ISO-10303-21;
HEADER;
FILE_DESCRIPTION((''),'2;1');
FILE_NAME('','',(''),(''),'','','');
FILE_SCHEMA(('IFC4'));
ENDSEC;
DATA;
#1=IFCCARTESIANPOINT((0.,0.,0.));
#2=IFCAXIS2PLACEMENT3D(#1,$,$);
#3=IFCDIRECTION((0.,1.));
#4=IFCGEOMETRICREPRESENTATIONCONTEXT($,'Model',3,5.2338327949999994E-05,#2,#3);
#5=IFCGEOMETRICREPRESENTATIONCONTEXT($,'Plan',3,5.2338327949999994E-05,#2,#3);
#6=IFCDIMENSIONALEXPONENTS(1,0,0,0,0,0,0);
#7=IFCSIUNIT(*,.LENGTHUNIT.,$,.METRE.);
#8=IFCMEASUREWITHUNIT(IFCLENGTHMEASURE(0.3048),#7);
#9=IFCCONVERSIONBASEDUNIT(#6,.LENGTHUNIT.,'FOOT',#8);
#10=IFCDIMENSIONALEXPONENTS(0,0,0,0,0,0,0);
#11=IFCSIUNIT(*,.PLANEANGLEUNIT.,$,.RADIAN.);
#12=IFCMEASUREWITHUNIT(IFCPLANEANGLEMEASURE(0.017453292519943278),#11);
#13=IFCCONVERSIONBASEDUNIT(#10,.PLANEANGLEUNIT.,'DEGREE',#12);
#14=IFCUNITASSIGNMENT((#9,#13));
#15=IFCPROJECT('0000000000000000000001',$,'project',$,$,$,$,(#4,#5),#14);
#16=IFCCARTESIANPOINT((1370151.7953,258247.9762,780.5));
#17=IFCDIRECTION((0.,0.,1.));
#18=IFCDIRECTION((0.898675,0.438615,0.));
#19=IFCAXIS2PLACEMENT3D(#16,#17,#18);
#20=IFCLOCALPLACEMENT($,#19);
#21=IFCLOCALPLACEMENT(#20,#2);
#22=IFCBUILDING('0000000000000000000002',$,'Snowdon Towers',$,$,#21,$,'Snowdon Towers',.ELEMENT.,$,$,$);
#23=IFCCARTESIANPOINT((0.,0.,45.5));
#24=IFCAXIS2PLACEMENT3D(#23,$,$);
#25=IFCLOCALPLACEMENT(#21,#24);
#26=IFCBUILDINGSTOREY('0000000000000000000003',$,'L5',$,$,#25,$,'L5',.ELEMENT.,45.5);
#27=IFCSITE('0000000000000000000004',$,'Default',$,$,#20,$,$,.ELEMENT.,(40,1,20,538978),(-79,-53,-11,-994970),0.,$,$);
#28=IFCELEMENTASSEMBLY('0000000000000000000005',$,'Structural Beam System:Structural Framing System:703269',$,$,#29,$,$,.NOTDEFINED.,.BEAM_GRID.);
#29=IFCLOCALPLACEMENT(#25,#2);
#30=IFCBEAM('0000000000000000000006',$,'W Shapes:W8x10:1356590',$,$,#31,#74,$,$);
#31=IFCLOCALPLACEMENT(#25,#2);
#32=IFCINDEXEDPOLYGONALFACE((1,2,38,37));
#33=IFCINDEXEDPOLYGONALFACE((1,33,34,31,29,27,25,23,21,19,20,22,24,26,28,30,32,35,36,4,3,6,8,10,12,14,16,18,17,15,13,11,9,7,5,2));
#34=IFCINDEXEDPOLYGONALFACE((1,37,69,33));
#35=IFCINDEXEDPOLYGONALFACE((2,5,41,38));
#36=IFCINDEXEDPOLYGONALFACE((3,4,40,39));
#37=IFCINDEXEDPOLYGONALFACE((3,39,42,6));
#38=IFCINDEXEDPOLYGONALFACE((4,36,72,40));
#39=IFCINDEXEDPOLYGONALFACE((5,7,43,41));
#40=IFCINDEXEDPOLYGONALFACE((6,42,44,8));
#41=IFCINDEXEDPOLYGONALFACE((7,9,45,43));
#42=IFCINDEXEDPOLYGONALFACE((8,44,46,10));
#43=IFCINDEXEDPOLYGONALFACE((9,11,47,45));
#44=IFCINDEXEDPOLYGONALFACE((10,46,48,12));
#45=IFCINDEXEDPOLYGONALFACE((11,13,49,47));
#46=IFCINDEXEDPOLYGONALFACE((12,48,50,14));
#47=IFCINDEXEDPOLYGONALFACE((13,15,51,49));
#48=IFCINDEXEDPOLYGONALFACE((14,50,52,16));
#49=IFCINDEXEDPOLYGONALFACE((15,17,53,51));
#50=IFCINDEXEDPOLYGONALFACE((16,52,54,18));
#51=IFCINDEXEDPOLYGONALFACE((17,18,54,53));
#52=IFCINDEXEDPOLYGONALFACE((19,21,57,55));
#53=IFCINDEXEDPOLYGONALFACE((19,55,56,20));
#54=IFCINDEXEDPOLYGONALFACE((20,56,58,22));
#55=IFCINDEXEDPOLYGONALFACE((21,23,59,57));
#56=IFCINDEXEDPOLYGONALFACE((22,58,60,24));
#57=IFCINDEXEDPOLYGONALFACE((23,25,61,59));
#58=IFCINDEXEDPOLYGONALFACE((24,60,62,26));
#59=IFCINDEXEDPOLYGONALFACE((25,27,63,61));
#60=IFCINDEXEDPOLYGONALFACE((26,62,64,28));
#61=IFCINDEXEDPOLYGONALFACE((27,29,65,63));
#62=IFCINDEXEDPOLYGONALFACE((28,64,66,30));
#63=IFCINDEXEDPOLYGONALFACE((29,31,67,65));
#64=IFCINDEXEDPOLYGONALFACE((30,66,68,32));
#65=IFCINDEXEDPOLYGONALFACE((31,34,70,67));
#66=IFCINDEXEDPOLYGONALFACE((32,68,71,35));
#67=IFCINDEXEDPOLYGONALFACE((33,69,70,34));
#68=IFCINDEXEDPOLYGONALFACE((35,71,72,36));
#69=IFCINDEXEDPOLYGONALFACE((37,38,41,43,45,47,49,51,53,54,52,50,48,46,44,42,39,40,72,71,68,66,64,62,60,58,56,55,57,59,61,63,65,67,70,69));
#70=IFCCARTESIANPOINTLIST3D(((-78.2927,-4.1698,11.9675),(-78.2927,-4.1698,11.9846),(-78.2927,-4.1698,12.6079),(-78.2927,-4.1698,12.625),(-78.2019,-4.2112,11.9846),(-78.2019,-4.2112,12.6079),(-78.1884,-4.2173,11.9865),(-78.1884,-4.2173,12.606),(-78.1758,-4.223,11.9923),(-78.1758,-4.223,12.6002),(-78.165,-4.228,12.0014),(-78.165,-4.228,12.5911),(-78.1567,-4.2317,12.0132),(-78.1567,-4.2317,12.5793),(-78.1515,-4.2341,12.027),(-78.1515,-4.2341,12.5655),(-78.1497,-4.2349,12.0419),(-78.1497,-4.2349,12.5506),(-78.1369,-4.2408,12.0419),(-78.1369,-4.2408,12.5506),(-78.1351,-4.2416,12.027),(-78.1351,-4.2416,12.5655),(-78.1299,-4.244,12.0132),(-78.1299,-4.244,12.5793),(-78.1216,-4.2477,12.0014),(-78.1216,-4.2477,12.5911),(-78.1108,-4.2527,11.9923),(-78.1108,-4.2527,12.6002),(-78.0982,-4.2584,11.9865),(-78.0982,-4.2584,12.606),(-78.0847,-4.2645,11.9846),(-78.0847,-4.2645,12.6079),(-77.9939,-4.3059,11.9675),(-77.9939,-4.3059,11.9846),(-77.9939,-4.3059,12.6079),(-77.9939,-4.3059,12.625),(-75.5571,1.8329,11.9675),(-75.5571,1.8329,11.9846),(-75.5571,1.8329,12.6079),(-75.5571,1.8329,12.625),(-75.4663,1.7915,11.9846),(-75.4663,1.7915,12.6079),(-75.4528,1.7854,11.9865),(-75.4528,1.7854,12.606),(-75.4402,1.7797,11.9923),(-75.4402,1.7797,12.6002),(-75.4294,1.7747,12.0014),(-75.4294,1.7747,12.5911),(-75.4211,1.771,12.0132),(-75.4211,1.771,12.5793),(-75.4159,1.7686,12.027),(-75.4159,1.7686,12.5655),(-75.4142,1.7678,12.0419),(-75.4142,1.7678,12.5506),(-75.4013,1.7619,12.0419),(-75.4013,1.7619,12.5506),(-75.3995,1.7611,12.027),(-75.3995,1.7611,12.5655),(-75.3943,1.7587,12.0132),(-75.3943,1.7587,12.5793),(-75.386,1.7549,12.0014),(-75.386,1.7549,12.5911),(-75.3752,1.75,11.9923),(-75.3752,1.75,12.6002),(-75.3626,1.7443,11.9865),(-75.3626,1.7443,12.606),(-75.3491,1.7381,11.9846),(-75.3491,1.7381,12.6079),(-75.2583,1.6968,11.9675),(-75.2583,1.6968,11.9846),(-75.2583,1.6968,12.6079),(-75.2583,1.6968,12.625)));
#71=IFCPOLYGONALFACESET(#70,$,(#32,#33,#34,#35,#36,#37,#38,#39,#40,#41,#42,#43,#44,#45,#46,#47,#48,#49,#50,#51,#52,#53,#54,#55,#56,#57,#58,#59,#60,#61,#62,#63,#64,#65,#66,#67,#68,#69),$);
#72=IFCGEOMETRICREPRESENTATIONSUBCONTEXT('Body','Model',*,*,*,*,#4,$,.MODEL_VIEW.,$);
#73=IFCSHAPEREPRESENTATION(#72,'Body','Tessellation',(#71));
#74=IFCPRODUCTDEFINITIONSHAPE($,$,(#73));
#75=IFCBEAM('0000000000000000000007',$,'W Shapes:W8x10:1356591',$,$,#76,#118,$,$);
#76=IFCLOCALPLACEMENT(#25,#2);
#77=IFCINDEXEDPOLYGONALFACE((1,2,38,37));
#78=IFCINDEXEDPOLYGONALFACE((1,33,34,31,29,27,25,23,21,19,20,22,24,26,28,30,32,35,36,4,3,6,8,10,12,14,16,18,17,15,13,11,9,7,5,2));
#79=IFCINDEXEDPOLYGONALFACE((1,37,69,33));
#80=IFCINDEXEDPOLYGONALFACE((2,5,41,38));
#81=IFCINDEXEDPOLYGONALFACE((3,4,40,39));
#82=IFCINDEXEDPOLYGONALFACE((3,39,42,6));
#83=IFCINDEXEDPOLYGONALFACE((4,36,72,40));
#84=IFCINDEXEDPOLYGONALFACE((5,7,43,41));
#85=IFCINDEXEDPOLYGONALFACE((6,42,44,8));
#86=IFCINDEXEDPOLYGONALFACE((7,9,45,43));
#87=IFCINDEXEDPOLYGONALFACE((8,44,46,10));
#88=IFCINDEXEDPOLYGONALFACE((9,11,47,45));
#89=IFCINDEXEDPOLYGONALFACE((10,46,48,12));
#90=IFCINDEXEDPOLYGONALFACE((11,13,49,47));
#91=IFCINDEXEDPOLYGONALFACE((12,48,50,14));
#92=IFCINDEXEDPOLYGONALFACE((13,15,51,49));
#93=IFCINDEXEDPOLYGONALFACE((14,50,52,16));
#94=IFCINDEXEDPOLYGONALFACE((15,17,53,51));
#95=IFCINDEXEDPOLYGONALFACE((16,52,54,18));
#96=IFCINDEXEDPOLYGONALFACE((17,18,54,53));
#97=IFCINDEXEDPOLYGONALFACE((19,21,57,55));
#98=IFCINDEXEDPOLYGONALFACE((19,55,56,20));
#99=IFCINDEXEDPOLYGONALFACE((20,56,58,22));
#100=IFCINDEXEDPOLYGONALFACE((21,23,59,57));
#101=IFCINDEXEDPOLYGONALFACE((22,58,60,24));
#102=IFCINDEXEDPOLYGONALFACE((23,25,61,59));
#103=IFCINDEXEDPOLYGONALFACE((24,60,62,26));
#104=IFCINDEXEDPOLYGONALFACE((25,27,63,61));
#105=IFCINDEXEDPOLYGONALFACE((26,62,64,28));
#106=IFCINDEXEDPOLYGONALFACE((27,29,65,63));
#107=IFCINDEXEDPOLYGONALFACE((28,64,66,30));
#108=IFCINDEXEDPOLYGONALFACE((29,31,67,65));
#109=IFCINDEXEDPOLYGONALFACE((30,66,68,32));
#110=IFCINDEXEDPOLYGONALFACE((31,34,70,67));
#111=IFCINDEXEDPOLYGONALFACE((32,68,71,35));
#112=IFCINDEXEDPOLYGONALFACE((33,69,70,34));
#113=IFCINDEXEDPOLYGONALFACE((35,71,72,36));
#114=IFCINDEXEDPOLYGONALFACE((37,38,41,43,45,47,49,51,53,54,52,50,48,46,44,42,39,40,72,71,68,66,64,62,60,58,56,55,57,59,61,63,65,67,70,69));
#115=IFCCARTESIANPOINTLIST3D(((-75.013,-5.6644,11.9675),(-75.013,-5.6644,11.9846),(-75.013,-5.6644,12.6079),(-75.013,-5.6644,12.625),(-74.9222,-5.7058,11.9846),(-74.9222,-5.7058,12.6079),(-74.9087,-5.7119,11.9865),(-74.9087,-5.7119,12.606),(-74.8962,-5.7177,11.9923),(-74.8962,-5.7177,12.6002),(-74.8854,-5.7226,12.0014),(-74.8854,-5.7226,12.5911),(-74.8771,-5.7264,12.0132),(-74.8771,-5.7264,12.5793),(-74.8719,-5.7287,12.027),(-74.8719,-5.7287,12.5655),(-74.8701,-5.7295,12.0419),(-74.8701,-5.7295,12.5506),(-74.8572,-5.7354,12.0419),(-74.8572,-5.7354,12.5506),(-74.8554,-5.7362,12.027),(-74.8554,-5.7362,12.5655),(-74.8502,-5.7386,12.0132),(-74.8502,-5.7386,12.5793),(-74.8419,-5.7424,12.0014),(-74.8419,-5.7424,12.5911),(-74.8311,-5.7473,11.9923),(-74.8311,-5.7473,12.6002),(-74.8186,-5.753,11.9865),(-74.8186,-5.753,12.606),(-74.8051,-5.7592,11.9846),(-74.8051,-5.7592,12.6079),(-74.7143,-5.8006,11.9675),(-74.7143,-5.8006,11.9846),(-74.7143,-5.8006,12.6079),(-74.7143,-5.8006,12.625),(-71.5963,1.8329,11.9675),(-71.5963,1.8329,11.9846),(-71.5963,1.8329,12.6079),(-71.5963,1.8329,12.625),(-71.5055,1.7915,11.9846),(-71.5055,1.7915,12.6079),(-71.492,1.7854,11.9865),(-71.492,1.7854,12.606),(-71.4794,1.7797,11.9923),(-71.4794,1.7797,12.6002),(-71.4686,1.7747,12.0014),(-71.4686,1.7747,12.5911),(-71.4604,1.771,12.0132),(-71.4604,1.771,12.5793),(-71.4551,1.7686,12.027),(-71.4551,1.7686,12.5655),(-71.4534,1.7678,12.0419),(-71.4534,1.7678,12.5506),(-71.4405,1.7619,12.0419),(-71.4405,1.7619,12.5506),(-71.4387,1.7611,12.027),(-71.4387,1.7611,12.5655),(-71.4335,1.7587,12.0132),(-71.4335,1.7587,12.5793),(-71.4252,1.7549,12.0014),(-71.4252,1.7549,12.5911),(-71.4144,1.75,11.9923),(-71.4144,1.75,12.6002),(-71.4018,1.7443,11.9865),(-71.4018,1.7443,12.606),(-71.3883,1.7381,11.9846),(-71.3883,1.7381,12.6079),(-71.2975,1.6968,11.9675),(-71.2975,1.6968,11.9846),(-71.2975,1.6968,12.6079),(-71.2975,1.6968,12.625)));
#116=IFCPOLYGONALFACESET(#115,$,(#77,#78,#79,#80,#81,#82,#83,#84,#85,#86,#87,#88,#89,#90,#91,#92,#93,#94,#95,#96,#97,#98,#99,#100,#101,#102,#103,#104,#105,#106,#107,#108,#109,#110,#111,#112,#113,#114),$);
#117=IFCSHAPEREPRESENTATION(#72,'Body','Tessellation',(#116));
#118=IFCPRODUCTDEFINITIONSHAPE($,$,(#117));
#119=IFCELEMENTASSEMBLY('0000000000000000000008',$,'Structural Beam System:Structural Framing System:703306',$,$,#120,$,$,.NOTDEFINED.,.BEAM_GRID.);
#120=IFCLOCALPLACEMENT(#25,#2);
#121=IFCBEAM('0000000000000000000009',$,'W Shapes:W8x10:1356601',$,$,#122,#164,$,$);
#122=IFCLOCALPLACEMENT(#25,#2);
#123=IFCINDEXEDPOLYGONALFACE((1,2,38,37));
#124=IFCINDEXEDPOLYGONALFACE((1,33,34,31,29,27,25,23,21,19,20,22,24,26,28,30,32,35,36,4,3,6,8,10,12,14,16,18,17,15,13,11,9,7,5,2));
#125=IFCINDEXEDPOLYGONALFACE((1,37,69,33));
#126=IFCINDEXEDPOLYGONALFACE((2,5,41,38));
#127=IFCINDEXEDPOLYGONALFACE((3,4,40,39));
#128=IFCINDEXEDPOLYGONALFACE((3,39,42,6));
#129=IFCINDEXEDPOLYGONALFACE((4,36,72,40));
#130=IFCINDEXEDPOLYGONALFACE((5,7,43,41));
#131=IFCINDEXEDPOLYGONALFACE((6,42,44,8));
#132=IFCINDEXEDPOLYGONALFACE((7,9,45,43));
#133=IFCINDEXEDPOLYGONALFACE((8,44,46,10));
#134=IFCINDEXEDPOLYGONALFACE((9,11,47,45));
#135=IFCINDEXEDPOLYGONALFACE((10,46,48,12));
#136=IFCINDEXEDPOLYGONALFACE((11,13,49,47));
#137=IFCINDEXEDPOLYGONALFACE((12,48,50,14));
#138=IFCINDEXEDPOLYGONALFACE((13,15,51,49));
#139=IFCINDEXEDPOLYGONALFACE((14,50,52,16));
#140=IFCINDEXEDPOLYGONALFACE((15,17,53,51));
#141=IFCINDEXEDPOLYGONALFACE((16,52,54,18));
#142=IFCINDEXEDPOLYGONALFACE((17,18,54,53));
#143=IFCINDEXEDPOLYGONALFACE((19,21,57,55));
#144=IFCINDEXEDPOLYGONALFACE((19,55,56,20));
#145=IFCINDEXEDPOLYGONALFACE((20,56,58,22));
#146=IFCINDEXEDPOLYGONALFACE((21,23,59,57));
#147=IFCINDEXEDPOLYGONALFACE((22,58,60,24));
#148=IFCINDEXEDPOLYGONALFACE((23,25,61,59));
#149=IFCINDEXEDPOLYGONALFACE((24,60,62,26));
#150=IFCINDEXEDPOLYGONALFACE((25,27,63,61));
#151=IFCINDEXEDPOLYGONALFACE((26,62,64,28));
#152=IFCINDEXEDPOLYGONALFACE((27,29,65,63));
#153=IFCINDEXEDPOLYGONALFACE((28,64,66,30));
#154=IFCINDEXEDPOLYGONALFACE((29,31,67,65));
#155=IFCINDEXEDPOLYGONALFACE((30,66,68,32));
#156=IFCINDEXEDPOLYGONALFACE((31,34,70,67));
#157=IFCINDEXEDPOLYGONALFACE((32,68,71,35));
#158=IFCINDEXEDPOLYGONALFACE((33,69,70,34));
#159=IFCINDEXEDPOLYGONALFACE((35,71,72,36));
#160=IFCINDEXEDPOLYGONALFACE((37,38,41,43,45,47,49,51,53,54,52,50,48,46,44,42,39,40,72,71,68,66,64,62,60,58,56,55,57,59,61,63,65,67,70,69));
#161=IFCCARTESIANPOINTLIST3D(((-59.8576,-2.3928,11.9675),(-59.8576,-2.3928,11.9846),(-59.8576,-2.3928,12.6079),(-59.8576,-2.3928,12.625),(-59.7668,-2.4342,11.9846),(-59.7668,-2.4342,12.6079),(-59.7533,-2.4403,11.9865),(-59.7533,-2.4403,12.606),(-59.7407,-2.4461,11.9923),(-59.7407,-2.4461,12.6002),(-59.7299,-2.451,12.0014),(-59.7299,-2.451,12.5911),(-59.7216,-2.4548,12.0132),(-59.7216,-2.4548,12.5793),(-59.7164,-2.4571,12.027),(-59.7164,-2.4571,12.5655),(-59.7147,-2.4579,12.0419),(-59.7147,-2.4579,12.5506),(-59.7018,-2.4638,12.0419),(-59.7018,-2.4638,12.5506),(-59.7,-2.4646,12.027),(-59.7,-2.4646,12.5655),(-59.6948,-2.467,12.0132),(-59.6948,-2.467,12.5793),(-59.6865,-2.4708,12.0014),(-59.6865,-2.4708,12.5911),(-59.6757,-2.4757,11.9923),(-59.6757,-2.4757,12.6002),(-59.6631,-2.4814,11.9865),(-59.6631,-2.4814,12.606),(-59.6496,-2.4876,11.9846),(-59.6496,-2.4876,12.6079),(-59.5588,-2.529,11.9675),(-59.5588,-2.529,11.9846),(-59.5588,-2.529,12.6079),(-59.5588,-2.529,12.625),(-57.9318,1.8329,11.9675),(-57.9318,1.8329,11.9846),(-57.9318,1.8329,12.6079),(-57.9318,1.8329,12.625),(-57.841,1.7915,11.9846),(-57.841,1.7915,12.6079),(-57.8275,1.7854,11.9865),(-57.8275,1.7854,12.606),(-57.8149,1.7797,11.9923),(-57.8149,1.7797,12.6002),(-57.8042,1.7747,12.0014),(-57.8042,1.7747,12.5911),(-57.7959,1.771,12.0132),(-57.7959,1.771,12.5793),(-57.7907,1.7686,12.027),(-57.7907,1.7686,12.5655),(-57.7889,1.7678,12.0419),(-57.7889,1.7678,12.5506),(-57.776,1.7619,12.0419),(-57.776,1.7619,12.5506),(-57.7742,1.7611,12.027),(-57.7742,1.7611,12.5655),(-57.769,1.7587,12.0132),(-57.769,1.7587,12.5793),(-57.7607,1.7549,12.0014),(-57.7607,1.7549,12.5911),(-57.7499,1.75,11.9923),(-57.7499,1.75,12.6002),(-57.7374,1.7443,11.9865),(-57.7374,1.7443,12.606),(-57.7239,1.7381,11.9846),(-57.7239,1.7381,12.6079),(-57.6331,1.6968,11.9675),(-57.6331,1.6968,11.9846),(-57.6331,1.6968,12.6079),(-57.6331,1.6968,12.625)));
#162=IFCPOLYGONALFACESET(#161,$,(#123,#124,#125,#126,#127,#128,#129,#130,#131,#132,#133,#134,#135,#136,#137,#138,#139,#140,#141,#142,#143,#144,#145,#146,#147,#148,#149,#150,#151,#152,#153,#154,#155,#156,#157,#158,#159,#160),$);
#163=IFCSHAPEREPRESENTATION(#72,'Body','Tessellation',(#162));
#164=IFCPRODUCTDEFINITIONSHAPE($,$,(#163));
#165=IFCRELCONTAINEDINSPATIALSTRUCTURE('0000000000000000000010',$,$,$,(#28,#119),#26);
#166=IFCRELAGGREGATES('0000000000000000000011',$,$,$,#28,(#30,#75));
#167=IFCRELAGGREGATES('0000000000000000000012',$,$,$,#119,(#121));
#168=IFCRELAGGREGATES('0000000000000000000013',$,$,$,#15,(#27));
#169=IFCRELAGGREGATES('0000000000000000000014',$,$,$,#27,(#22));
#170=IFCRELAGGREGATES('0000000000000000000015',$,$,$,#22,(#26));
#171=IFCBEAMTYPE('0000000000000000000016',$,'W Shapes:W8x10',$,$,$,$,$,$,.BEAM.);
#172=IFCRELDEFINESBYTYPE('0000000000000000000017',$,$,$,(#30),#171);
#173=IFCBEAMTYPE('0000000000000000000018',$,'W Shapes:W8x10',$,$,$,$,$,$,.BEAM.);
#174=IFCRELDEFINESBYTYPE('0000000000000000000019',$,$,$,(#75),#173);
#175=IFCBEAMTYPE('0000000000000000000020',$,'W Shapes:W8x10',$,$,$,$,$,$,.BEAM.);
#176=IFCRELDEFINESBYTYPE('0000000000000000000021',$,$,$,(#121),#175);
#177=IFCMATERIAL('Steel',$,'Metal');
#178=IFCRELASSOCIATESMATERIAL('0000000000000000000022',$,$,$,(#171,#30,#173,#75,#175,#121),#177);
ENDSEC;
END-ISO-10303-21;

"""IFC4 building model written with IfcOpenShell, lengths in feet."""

from ifc_helpers import new_model, entity, si_unit, converted_unit, direction, frame, origin, place, context, subcontext, project, spatial, line, arc, indexed_curve, outline, extrude, source, transform, mapped, material, type_object, type_shapes, element, aggregate, save


model = new_model("IFC4")

# Units and contexts
model_context = context("Model", 3, precision=5.2338327949999994e-05, world=origin(), true_north=direction((0.0, 1.0)))
plan_context = context("Plan", 3, precision=5.2338327949999994e-05, world=origin(), true_north=direction((0.0, 1.0)))
body_context = subcontext(model_context, "Body", "Model", "MODEL_VIEW")
ifc_project = project(units=[converted_unit("LENGTHUNIT", "FOOT", entity("IfcLengthMeasure", 0.3048), si_unit("LENGTHUNIT", "METRE"), dimensions=[1, 0, 0, 0, 0, 0, 0]), converted_unit("PLANEANGLEUNIT", "DEGREE", entity("IfcPlaneAngleMeasure", 0.017453292519943278), si_unit("PLANEANGLEUNIT", "RADIAN"), dimensions=[0, 0, 0, 0, 0, 0, 0])], contexts=[model_context, plan_context])

# Site, building, storey
site_placement = place(None, frame((1370151.7953, 258247.9762, 780.5), z_axis=(0.0, 0.0, 1.0), x_axis=(0.898675, 0.438615, 0.0)))
site = spatial("IfcSite", under=ifc_project, at=site_placement, Name="Default", CompositionType="ELEMENT", RefLatitude=(40, 1, 20, 538978), RefLongitude=(-79, -53, -11, -994970), RefElevation=0.0)
building_placement = place(site_placement, origin())
building = spatial("IfcBuilding", under=site, at=building_placement, Name="Snowdon Towers", LongName="Snowdon Towers", CompositionType="ELEMENT")
storey_placement = place(building_placement, frame((0.0, 0.0, 45.5)))
storey = spatial("IfcBuildingStorey", under=building, at=storey_placement, Name="L5", LongName="L5", CompositionType="ELEMENT", Elevation=45.5)

# Shared definitions
ifc_material_1 = material(Name="Steel", Category="Metal")

# Element assemblies, beams
assembly_1_placement = place(storey_placement, origin())
assembly_1 = element("IfcElementAssembly", 1, at=assembly_1_placement, inside=storey, Name="Structural Beam System:Structural Framing System:703269", AssemblyPlace="NOTDEFINED", PredefinedType="BEAM_GRID")
beam_type_1 = type_object("IfcBeamType", Name="W Shapes:W8x10", PredefinedType="BEAM", material=ifc_material_1)
shared_shape_1 = source(origin(), body_context, "Body", "SweptSolid", [
    extrude(outline(indexed_curve([(-0.3287, -0.1642), (-0.3117, -0.1642), (-0.3117, -0.0644), (-0.2949, -0.0239), (-0.2544, -0.0071), (0.2544, -0.0071), (0.2949, -0.0239), (0.3117, -0.0644), (0.3117, -0.1642), (0.3288, -0.1642), (0.3288, 0.1642), (0.3117, 0.1642), (0.3117, 0.0644), (0.2949, 0.0239), (0.2544, 0.0071), (-0.2544, 0.0071), (-0.2949, 0.0239), (-0.3117, 0.0644), (-0.3117, 0.1642), (-0.3287, 0.1642)], segments=[line(1, 2, 3), arc(3, 4, 5), line(5, 6), arc(6, 7, 8), line(8, 9, 10, 11, 12, 13), arc(13, 14, 15), line(15, 16), arc(16, 17, 18), line(18, 19, 20, 1)], self_intersect=False)), frame((-3.5462, 0.0, 0.0), z_axis=(1.0, 0.0, 0.0), x_axis=(0.0, 0.0, -1.0)), (0.0, 0.0, 1.0), 6.5966),
])
type_shapes(beam_type_1, [shared_shape_1])
beam_1_placement = place(assembly_1_placement, frame((-76.6727, -1.0109, 12.2963), z_axis=(0.0, 0.0, 1.0), x_axis=(0.414693, 0.909961, 0.0)))
beam_1 = element("IfcBeam", 2, at=beam_1_placement, type_object=beam_type_1, material=ifc_material_1, Name="W Shapes:W8x10:1356590", context=body_context, shape_type="MappedRepresentation", body=[
    mapped(shared_shape_1, transform((0.0, 0.0, 0.0), scale=1.0)),
])
beam_type_2 = type_object("IfcBeamType", Name="W Shapes:W8x10", PredefinedType="BEAM", material=ifc_material_1)
shared_shape_2 = source(origin(), body_context, "Body", "SweptSolid", [
    extrude(outline(indexed_curve([(-0.3287, -0.1642), (-0.3117, -0.1642), (-0.3117, -0.0644), (-0.2949, -0.0239), (-0.2544, -0.0071), (0.2544, -0.0071), (0.2949, -0.0239), (0.3117, -0.0644), (0.3117, -0.1642), (0.3288, -0.1642), (0.3288, 0.1642), (0.3117, 0.1642), (0.3117, 0.0644), (0.2949, 0.0239), (0.2544, 0.0071), (-0.2544, 0.0071), (-0.2949, 0.0239), (-0.3117, 0.0644), (-0.3117, 0.1642), (-0.3287, 0.1642)], segments=[line(1, 2, 3), arc(3, 4, 5), line(5, 6), arc(6, 7, 8), line(8, 9, 10, 11, 12, 13), arc(13, 14, 15), line(15, 16), arc(16, 17, 18), line(18, 19, 20, 1)], self_intersect=False)), frame((-4.3675, 0.0, 0.0), z_axis=(1.0, 0.0, 0.0), x_axis=(0.0, 0.0, -1.0)), (0.0, 0.0, 1.0), 8.2392),
])
type_shapes(beam_type_2, [shared_shape_2])
beam_2_placement = place(assembly_1_placement, frame((-73.0525, -1.7582, 12.2963), z_axis=(0.0, 0.0, 1.0), x_axis=(0.414693, 0.909961, 0.0)))
beam_2 = element("IfcBeam", 3, at=beam_2_placement, type_object=beam_type_2, material=ifc_material_1, Name="W Shapes:W8x10:1356591", context=body_context, shape_type="MappedRepresentation", body=[
    mapped(shared_shape_2, transform((0.0, 0.0, 0.0), scale=1.0)),
])
aggregate(assembly_1, [beam_1, beam_2])
assembly_2_placement = place(storey_placement, origin())
assembly_2 = element("IfcElementAssembly", 4, at=assembly_2_placement, inside=storey, Name="Structural Beam System:Structural Framing System:703306", AssemblyPlace="NOTDEFINED", PredefinedType="BEAM_GRID")
beam_type_3 = type_object("IfcBeamType", Name="W Shapes:W8x10", PredefinedType="BEAM", material=ifc_material_1)
shared_shape_3 = source(origin(), body_context, "Body", "SweptSolid", [
    extrude(outline(indexed_curve([(-0.3287, -0.1642), (-0.3117, -0.1642), (-0.3117, -0.0644), (-0.2949, -0.0239), (-0.2544, -0.0071), (0.2544, -0.0071), (0.2949, -0.0239), (0.3117, -0.0644), (0.3117, -0.1642), (0.3288, -0.1642), (0.3288, 0.1642), (0.3117, 0.1642), (0.3117, 0.0644), (0.2949, 0.0239), (0.2544, 0.0071), (-0.2544, 0.0071), (-0.2949, 0.0239), (-0.3117, 0.0644), (-0.3117, 0.1642), (-0.3287, 0.1642)], segments=[line(1, 2, 3), arc(3, 4, 5), line(5, 6), arc(6, 7, 8), line(8, 9, 10, 11, 12, 13), arc(13, 14, 15), line(15, 16), arc(16, 17, 18), line(18, 19, 20, 1)], self_intersect=False)), frame((-2.5698, 0.0, 0.0), z_axis=(1.0, 0.0, 0.0), x_axis=(0.0, 0.0, -1.0)), (0.0, 0.0, 1.0), 4.6438),
])
type_shapes(beam_type_3, [shared_shape_3])
beam_3_placement = place(assembly_2_placement, frame((-58.6425, -0.1224, 12.2963), z_axis=(0.0, 0.0, 1.0), x_axis=(0.414693, 0.909961, 0.0)))
beam_3 = element("IfcBeam", 5, at=beam_3_placement, type_object=beam_type_3, material=ifc_material_1, Name="W Shapes:W8x10:1356601", context=body_context, shape_type="MappedRepresentation", body=[
    mapped(shared_shape_3, transform((0.0, 0.0, 0.0), scale=1.0)),
])
aggregate(assembly_2, [beam_3])

save(model, "model.ifc")
